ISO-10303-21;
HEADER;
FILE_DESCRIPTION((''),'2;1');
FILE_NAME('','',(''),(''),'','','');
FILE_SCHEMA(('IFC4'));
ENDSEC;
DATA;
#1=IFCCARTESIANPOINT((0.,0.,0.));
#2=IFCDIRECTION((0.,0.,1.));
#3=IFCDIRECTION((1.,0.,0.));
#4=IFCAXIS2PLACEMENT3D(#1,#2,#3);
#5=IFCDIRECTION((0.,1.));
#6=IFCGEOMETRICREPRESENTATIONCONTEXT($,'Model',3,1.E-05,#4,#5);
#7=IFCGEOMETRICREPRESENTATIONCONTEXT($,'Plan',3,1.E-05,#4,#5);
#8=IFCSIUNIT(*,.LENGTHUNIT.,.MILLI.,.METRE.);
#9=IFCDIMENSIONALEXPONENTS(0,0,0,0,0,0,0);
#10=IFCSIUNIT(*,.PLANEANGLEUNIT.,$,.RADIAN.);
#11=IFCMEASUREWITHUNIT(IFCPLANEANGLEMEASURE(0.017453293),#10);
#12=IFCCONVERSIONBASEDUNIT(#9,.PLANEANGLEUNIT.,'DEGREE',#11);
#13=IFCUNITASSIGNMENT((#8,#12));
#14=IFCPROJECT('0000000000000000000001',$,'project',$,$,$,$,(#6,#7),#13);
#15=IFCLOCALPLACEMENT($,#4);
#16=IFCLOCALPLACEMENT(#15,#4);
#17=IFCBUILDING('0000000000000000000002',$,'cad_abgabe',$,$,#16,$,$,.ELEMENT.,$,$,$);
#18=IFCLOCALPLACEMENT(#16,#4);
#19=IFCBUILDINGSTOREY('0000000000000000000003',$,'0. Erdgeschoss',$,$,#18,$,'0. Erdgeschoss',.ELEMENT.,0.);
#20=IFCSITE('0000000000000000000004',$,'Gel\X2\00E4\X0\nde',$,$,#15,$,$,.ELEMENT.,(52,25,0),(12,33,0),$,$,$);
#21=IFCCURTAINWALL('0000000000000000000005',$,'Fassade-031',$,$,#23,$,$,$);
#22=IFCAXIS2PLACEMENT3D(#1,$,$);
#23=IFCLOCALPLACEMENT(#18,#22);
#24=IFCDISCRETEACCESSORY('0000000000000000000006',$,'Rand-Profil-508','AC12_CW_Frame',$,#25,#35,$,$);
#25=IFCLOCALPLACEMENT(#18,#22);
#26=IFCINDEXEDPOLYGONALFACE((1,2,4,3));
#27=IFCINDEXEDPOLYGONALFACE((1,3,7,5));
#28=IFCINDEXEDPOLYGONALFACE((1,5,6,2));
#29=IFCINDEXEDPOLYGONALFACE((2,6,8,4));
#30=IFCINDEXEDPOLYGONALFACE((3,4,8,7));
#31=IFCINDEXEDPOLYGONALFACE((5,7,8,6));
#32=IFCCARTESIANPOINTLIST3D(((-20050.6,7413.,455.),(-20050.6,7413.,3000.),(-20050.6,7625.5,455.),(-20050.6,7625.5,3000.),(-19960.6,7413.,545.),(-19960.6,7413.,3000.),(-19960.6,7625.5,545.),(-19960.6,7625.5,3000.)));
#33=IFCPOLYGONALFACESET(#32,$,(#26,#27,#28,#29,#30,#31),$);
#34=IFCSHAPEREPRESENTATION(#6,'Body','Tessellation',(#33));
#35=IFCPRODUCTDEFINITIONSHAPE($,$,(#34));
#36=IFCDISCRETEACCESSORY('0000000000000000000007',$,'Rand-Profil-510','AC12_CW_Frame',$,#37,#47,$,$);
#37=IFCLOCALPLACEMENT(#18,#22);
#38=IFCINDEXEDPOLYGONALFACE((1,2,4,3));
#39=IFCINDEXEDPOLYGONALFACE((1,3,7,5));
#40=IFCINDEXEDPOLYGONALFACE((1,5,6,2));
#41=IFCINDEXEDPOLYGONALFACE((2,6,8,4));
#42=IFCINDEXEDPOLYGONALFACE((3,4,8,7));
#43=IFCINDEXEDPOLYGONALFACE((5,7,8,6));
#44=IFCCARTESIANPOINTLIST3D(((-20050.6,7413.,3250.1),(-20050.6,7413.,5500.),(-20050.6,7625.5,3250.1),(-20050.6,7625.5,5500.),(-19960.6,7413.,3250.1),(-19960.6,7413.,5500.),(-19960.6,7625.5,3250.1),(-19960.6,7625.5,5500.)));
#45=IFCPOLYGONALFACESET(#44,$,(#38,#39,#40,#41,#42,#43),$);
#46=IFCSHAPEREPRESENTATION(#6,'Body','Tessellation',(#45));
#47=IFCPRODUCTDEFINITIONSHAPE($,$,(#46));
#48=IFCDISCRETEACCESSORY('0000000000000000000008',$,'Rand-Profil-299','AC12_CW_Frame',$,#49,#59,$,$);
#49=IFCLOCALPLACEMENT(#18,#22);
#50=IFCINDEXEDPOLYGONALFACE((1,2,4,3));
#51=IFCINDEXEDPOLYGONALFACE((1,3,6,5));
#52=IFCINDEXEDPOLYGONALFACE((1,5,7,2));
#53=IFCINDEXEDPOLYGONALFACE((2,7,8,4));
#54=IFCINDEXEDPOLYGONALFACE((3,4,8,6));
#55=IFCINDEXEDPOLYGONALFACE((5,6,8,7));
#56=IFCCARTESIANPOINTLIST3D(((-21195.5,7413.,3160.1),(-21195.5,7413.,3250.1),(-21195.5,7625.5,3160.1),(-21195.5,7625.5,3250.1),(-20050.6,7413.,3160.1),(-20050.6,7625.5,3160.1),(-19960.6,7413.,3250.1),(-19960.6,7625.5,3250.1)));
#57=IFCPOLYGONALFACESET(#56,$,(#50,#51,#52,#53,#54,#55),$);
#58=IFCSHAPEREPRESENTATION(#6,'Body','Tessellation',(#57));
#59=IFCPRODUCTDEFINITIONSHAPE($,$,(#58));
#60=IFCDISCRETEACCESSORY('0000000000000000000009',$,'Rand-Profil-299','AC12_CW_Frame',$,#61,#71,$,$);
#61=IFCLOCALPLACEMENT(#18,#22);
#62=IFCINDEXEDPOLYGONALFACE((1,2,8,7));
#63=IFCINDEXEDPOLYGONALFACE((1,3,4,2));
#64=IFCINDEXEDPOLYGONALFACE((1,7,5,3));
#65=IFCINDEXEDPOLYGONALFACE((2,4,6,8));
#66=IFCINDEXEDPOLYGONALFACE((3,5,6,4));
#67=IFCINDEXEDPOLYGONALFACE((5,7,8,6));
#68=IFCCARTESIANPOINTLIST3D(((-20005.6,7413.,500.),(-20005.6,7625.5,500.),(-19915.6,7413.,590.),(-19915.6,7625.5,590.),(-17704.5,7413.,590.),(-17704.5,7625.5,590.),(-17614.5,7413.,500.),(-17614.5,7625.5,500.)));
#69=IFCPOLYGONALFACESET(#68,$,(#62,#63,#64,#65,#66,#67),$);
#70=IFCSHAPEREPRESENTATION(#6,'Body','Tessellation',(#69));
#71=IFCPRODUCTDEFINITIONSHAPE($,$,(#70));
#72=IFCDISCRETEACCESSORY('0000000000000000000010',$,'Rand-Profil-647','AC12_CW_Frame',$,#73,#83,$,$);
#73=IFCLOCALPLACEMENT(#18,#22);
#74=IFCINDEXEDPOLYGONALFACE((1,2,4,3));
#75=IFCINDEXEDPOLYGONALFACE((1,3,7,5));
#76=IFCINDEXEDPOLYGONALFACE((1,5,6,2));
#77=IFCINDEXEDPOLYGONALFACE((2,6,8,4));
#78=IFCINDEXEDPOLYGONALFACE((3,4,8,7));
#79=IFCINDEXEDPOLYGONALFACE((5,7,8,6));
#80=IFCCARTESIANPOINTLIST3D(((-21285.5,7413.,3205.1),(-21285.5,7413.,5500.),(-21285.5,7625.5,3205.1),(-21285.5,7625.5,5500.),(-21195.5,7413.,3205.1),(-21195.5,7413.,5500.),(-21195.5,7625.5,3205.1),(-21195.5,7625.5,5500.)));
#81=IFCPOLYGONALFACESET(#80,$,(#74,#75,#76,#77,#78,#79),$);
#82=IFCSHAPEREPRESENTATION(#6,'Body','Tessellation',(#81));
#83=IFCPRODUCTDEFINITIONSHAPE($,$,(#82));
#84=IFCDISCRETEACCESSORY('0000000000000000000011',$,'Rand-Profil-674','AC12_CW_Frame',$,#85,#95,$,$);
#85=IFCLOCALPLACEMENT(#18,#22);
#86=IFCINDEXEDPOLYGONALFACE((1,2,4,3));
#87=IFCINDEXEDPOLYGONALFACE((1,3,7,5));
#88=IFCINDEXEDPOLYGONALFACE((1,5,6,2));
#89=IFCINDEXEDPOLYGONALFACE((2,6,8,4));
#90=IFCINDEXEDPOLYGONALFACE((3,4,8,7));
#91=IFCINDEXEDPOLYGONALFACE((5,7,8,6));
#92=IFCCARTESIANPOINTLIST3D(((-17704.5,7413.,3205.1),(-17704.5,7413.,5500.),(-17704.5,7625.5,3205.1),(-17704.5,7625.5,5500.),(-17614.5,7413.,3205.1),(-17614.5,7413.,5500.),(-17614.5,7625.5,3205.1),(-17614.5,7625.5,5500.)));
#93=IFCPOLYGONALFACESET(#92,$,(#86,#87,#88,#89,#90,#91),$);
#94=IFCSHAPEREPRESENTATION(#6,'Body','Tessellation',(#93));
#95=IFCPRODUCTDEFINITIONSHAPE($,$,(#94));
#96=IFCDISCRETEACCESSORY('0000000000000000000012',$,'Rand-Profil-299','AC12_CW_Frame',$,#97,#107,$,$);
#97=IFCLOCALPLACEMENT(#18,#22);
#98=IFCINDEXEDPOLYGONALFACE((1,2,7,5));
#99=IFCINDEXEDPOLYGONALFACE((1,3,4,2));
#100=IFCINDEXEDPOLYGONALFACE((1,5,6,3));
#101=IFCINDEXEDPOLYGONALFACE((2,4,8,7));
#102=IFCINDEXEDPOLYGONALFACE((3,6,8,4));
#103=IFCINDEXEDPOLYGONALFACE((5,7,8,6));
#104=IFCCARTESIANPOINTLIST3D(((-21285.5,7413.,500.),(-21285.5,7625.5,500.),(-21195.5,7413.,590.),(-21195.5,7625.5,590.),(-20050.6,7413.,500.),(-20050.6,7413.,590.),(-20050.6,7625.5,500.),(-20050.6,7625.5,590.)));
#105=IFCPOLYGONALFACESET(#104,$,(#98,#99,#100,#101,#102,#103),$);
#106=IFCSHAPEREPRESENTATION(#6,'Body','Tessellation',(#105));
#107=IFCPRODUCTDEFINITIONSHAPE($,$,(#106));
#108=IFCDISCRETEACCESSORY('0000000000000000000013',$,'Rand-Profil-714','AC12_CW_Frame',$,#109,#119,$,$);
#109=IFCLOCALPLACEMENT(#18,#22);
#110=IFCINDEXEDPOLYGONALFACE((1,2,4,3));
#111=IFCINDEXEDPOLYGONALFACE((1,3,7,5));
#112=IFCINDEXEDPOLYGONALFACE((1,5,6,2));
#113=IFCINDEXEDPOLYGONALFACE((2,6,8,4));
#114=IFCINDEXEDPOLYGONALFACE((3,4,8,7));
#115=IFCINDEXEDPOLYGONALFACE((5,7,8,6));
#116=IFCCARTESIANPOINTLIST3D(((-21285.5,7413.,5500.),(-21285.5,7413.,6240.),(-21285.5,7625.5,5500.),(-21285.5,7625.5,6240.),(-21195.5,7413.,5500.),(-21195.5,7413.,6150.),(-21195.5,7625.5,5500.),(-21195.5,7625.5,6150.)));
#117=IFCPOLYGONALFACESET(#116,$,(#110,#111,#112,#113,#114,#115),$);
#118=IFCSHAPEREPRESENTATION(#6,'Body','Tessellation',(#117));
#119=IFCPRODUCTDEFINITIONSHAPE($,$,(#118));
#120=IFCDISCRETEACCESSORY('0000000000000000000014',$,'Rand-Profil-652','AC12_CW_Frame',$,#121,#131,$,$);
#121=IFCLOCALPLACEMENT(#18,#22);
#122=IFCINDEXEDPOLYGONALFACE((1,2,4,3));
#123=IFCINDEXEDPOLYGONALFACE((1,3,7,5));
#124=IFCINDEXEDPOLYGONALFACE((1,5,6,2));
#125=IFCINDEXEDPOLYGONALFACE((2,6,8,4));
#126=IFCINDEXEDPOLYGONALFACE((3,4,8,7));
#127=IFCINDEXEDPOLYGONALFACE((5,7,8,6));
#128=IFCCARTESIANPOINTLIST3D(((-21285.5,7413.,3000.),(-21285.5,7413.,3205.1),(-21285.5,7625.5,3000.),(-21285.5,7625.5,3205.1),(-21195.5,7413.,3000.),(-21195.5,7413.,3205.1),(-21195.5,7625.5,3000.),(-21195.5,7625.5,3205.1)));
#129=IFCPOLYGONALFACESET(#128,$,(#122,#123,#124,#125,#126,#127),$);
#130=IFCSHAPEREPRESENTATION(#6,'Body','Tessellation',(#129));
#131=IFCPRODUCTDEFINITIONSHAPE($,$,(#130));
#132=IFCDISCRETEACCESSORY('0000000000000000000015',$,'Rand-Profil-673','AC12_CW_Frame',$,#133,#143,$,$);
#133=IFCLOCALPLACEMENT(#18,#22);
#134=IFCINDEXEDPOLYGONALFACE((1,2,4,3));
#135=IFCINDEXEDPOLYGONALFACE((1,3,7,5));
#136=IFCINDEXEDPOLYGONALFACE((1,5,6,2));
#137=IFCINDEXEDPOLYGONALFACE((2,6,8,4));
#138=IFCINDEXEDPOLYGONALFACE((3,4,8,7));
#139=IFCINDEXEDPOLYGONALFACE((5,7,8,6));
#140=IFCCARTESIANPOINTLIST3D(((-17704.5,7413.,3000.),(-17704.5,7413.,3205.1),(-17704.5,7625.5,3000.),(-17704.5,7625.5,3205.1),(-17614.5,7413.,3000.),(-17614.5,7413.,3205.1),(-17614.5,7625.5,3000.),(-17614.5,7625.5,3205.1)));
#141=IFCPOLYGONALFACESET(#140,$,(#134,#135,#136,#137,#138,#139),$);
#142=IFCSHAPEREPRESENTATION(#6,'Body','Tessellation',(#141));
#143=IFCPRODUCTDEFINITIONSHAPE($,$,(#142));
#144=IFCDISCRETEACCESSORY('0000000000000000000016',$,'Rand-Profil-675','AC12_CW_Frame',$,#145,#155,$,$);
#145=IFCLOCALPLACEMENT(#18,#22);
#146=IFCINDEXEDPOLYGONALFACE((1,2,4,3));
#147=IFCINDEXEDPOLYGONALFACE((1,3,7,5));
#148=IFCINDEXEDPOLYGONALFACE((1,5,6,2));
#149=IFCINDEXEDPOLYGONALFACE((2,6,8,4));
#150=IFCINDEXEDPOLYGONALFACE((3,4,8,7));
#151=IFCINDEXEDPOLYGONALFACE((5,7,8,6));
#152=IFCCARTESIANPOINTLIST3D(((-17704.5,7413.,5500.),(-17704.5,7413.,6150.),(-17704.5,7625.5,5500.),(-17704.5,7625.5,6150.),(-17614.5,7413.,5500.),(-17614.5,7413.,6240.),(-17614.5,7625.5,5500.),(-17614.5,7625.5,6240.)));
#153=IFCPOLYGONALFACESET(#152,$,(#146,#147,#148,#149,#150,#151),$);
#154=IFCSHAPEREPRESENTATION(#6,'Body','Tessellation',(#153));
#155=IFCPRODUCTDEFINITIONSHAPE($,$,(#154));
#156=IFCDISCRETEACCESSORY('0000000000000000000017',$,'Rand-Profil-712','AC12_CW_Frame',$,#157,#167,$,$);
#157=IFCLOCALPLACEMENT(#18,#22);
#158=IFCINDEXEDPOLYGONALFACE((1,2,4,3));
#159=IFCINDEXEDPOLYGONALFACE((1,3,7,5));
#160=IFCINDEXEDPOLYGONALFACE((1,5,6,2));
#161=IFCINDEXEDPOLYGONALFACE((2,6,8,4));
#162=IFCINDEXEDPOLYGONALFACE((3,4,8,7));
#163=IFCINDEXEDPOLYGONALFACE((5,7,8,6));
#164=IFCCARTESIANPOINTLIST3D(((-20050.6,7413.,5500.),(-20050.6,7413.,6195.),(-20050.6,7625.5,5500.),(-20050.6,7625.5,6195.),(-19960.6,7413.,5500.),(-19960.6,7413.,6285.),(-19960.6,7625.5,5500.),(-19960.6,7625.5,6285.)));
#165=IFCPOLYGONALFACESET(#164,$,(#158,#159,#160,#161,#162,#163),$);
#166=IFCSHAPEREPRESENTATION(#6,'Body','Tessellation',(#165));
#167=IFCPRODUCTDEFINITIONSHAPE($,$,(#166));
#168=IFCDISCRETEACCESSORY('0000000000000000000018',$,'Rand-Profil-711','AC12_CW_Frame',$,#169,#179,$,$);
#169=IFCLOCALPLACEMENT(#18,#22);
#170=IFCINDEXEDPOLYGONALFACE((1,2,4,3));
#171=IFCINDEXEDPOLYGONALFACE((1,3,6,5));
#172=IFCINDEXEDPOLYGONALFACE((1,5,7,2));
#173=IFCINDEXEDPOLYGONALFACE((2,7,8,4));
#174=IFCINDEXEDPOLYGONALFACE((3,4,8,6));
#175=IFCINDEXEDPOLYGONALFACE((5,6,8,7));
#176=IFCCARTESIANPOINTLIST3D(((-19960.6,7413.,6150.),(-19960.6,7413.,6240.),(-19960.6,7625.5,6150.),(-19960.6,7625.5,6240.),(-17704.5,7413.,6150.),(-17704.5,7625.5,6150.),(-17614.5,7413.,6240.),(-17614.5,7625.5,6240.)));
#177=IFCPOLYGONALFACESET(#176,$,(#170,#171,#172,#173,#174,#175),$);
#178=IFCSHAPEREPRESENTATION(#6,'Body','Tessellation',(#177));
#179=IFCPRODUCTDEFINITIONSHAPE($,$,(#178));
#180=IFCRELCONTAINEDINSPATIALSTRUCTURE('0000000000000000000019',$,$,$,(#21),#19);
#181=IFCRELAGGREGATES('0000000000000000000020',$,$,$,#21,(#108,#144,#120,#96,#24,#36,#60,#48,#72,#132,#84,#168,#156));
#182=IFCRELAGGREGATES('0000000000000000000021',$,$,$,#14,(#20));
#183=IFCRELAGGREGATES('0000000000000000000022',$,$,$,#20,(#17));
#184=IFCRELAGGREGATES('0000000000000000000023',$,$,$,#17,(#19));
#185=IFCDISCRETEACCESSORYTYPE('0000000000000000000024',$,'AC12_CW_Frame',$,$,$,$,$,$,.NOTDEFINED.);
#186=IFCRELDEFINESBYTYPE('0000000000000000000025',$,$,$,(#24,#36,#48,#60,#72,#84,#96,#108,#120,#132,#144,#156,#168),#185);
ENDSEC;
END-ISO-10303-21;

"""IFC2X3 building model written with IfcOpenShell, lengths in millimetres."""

from ifc_helpers import new_model, entity, si_unit, converted_unit, direction, frame, origin_with_axes, place, context, project, spatial, polyline, outline, extrude, source, transform, mapped, type_object, element, aggregate, save


model = new_model("IFC2X3")

# Units and contexts
model_context = context("Model", 3, precision=1e-05, world=origin_with_axes(), true_north=direction((0.0, 1.0)))
plan_context = context("Plan", 3, precision=1e-05, world=origin_with_axes(), true_north=direction((0.0, 1.0)))
ifc_project = project(units=[si_unit("LENGTHUNIT", "METRE", prefix="MILLI"), converted_unit("PLANEANGLEUNIT", "DEGREE", entity("IfcPlaneAngleMeasure", 0.017453293), si_unit("PLANEANGLEUNIT", "RADIAN"), dimensions=[0, 0, 0, 0, 0, 0, 0])], contexts=[model_context, plan_context])

# Site, building, storey
site_placement = place(None, origin_with_axes())
site = spatial("IfcSite", under=ifc_project, at=site_placement, Name="Gelände", CompositionType="ELEMENT", RefLatitude=(52, 25, 0), RefLongitude=(12, 33, 0))
building_placement = place(site_placement, origin_with_axes())
building = spatial("IfcBuilding", under=site, at=building_placement, Name="cad_abgabe", CompositionType="ELEMENT")
storey_placement = place(building_placement, origin_with_axes())
storey = spatial("IfcBuildingStorey", under=building, at=storey_placement, Name="0. Erdgeschoss", LongName="0. Erdgeschoss", CompositionType="ELEMENT", Elevation=0.0)

# Curtain wall, discrete accessories
curtain_wall_placement = place(storey_placement, frame((-17614.5, 7448.0, 500.0), z_axis=(0.0, 0.0, 1.0), x_axis=(-1.0, 0.0, 0.0)))
curtain_wall = element("IfcCurtainWall", 1, at=curtain_wall_placement, inside=storey, Name="Fassade-031")
discrete_accessory_type = type_object("IfcDiscreteAccessoryType", Name="AC12_CW_Frame")
shared_shape_1 = source(origin_with_axes(), model_context, "Body", "SweptSolid", [
    extrude(outline(polyline([(0.0, 0.0), (2545.0, 0.0), (2545.0, -90.0), (90.0, -90.0), (0.0, 0.0)])), origin_with_axes(), (0.0, 0.0, 1.0), 212.5),
])
discrete_accessory_1_placement = place(storey_placement, frame((-20050.6, 7625.5, 455.0), z_axis=(0.0, -1.0, 0.0), x_axis=(0.0, 0.0, 1.0)))
discrete_accessory_1 = element("IfcDiscreteAccessory", 2, at=discrete_accessory_1_placement, type_object=discrete_accessory_type, Name="Rand-Profil-508", Description="AC12_CW_Frame", context=model_context, shape_type="MappedRepresentation", body=[
    mapped(shared_shape_1, transform((0.0, 0.0, 0.0), scale=1.0)),
])
shared_shape_2 = source(origin_with_axes(), model_context, "Body", "SweptSolid", [
    extrude(outline(polyline([(0.0, 0.0), (2249.9, 0.0), (2249.9, -212.5), (0.0, -212.5), (0.0, 0.0)])), origin_with_axes(), (0.0, 0.0, 1.0), 90.0),
])
discrete_accessory_2_placement = place(storey_placement, frame((-19960.6, 7625.5, 3250.1), z_axis=(-1.0, 0.0, 0.0), x_axis=(0.0, 0.0, 1.0)))
discrete_accessory_2 = element("IfcDiscreteAccessory", 3, at=discrete_accessory_2_placement, type_object=discrete_accessory_type, Name="Rand-Profil-510", Description="AC12_CW_Frame", context=model_context, shape_type="MappedRepresentation", body=[
    mapped(shared_shape_2, transform((0.0, 0.0, 0.0), scale=1.0)),
])
shared_shape_3 = source(origin_with_axes(), model_context, "Body", "SweptSolid", [
    extrude(outline(polyline([(0.0, 0.0), (1144.8, 0.0), (1144.8, -90.0), (-90.0, -90.0), (0.0, 0.0)])), origin_with_axes(), (0.0, 0.0, 1.0), 212.5),
])
discrete_accessory_3_placement = place(storey_placement, frame((-20050.6, 7625.5, 3160.1), z_axis=(0.0, -1.0, 0.0), x_axis=(-1.0, 0.0, 0.0)))
discrete_accessory_3 = element("IfcDiscreteAccessory", 4, at=discrete_accessory_3_placement, type_object=discrete_accessory_type, Name="Rand-Profil-299", Description="AC12_CW_Frame", context=model_context, shape_type="MappedRepresentation", body=[
    mapped(shared_shape_3, transform((0.0, 0.0, 0.0), scale=1.0)),
])
shared_shape_4 = source(origin_with_axes(), model_context, "Body", "SweptSolid", [
    extrude(outline(polyline([(0.0, 0.0), (2391.1, 0.0), (2301.1, -90.0), (90.0, -90.0), (0.0, 0.0)])), origin_with_axes(), (0.0, 0.0, 1.0), 212.5),
])
discrete_accessory_4_placement = place(storey_placement, frame((-17614.5, 7625.5, 500.0), z_axis=(0.0, -1.0, 0.0), x_axis=(-1.0, 0.0, 0.0)))
discrete_accessory_4 = element("IfcDiscreteAccessory", 5, at=discrete_accessory_4_placement, type_object=discrete_accessory_type, Name="Rand-Profil-299", Description="AC12_CW_Frame", context=model_context, shape_type="MappedRepresentation", body=[
    mapped(shared_shape_4, transform((0.0, 0.0, 0.0), scale=1.0)),
])
shared_shape_5 = source(origin_with_axes(), model_context, "Body", "SweptSolid", [
    extrude(outline(polyline([(0.0, 0.0), (2294.9, 0.0), (2294.9, -212.5), (0.0, -212.5), (0.0, 0.0)])), origin_with_axes(), (0.0, 0.0, 1.0), 90.0),
])
discrete_accessory_5_placement = place(storey_placement, frame((-21195.5, 7625.5, 3205.1), z_axis=(-1.0, 0.0, 0.0), x_axis=(0.0, 0.0, 1.0)))
discrete_accessory_5 = element("IfcDiscreteAccessory", 6, at=discrete_accessory_5_placement, type_object=discrete_accessory_type, Name="Rand-Profil-647", Description="AC12_CW_Frame", context=model_context, shape_type="MappedRepresentation", body=[
    mapped(shared_shape_5, transform((0.0, 0.0, 0.0), scale=1.0)),
])
discrete_accessory_6_placement = place(storey_placement, frame((-17704.5, 7625.5, 5500.0), z_axis=(1.0, 0.0, 0.0), x_axis=(0.0, 0.0, -1.0)))
discrete_accessory_6 = element("IfcDiscreteAccessory", 7, at=discrete_accessory_6_placement, type_object=discrete_accessory_type, Name="Rand-Profil-674", Description="AC12_CW_Frame", context=model_context, shape_type="MappedRepresentation", body=[
    mapped(shared_shape_5, transform((0.0, 0.0, 0.0), scale=1.0)),
])
shared_shape_6 = source(origin_with_axes(), model_context, "Body", "SweptSolid", [
    extrude(outline(polyline([(0.0, 0.0), (1234.8, 0.0), (1144.8, -90.0), (0.0, -90.0), (0.0, 0.0)])), origin_with_axes(), (0.0, 0.0, 1.0), 212.5),
])
discrete_accessory_7_placement = place(storey_placement, frame((-20050.6, 7625.5, 500.0), z_axis=(0.0, -1.0, 0.0), x_axis=(-1.0, 0.0, 0.0)))
discrete_accessory_7 = element("IfcDiscreteAccessory", 8, at=discrete_accessory_7_placement, type_object=discrete_accessory_type, Name="Rand-Profil-299", Description="AC12_CW_Frame", context=model_context, shape_type="MappedRepresentation", body=[
    mapped(shared_shape_6, transform((0.0, 0.0, 0.0), scale=1.0)),
])
shared_shape_7 = source(origin_with_axes(), model_context, "Body", "SweptSolid", [
    extrude(outline(polyline([(0.0, 0.0), (740.0, 0.0), (650.0, -90.0), (0.0, -90.0), (0.0, 0.0)])), origin_with_axes(), (0.0, 0.0, 1.0), 212.5),
])
discrete_accessory_8_placement = place(storey_placement, frame((-21285.5, 7625.5, 5500.0), z_axis=(0.0, -1.0, 0.0), x_axis=(0.0, 0.0, 1.0)))
discrete_accessory_8 = element("IfcDiscreteAccessory", 9, at=discrete_accessory_8_placement, type_object=discrete_accessory_type, Name="Rand-Profil-714", Description="AC12_CW_Frame", context=model_context, shape_type="MappedRepresentation", body=[
    mapped(shared_shape_7, transform((0.0, 0.0, 0.0), scale=1.0)),
])
shared_shape_8 = source(origin_with_axes(), model_context, "Body", "SweptSolid", [
    extrude(outline(polyline([(0.0, 0.0), (205.1, 0.0), (205.1, -212.5), (0.0, -212.5), (0.0, 0.0)])), origin_with_axes(), (0.0, 0.0, 1.0), 90.0),
])
discrete_accessory_9_placement = place(storey_placement, frame((-21195.5, 7625.5, 3000.0), z_axis=(-1.0, 0.0, 0.0), x_axis=(0.0, 0.0, 1.0)))
discrete_accessory_9 = element("IfcDiscreteAccessory", 10, at=discrete_accessory_9_placement, type_object=discrete_accessory_type, Name="Rand-Profil-652", Description="AC12_CW_Frame", context=model_context, shape_type="MappedRepresentation", body=[
    mapped(shared_shape_8, transform((0.0, 0.0, 0.0), scale=1.0)),
])
discrete_accessory_10_placement = place(storey_placement, frame((-17704.5, 7625.5, 3205.1), z_axis=(1.0, 0.0, 0.0), x_axis=(0.0, 0.0, -1.0)))
discrete_accessory_10 = element("IfcDiscreteAccessory", 11, at=discrete_accessory_10_placement, type_object=discrete_accessory_type, Name="Rand-Profil-673", Description="AC12_CW_Frame", context=model_context, shape_type="MappedRepresentation", body=[
    mapped(shared_shape_8, transform((0.0, 0.0, 0.0), scale=1.0)),
])
shared_shape_9 = source(origin_with_axes(), model_context, "Body", "SweptSolid", [
    extrude(outline(polyline([(0.0, 0.0), (740.0, 0.0), (740.0, -90.0), (90.0, -90.0), (0.0, 0.0)])), origin_with_axes(), (0.0, 0.0, 1.0), 212.5),
])
discrete_accessory_11_placement = place(storey_placement, frame((-17614.5, 7625.5, 6240.0), z_axis=(0.0, -1.0, 0.0), x_axis=(0.0, 0.0, -1.0)))
discrete_accessory_11 = element("IfcDiscreteAccessory", 12, at=discrete_accessory_11_placement, type_object=discrete_accessory_type, Name="Rand-Profil-675", Description="AC12_CW_Frame", context=model_context, shape_type="MappedRepresentation", body=[
    mapped(shared_shape_9, transform((0.0, 0.0, 0.0), scale=1.0)),
])
shared_shape_10 = source(origin_with_axes(), model_context, "Body", "SweptSolid", [
    extrude(outline(polyline([(0.0, 0.0), (695.0, 0.0), (785.0, -90.0), (0.0, -90.0), (0.0, 0.0)])), origin_with_axes(), (0.0, 0.0, 1.0), 212.5),
])
discrete_accessory_12_placement = place(storey_placement, frame((-20050.6, 7625.5, 5500.0), z_axis=(0.0, -1.0, 0.0), x_axis=(0.0, 0.0, 1.0)))
discrete_accessory_12 = element("IfcDiscreteAccessory", 13, at=discrete_accessory_12_placement, type_object=discrete_accessory_type, Name="Rand-Profil-712", Description="AC12_CW_Frame", context=model_context, shape_type="MappedRepresentation", body=[
    mapped(shared_shape_10, transform((0.0, 0.0, 0.0), scale=1.0)),
])
shared_shape_11 = source(origin_with_axes(), model_context, "Body", "SweptSolid", [
    extrude(outline(polyline([(0.0, 0.0), (2346.1, 0.0), (2256.1, -90.0), (0.0, -90.0), (0.0, 0.0)])), origin_with_axes(), (0.0, 0.0, 1.0), 212.5),
])
discrete_accessory_13_placement = place(storey_placement, frame((-19960.6, 7625.5, 6240.0), z_axis=(0.0, -1.0, 0.0), x_axis=(1.0, 0.0, 0.0)))
discrete_accessory_13 = element("IfcDiscreteAccessory", 14, at=discrete_accessory_13_placement, type_object=discrete_accessory_type, Name="Rand-Profil-711", Description="AC12_CW_Frame", context=model_context, shape_type="MappedRepresentation", body=[
    mapped(shared_shape_11, transform((0.0, 0.0, 0.0), scale=1.0)),
])
aggregate(curtain_wall, [discrete_accessory_8, discrete_accessory_11, discrete_accessory_9, discrete_accessory_7, discrete_accessory_1, discrete_accessory_2, discrete_accessory_4, discrete_accessory_3, discrete_accessory_5, discrete_accessory_10, discrete_accessory_6, discrete_accessory_13, discrete_accessory_12])

save(model, "model.ifc")
